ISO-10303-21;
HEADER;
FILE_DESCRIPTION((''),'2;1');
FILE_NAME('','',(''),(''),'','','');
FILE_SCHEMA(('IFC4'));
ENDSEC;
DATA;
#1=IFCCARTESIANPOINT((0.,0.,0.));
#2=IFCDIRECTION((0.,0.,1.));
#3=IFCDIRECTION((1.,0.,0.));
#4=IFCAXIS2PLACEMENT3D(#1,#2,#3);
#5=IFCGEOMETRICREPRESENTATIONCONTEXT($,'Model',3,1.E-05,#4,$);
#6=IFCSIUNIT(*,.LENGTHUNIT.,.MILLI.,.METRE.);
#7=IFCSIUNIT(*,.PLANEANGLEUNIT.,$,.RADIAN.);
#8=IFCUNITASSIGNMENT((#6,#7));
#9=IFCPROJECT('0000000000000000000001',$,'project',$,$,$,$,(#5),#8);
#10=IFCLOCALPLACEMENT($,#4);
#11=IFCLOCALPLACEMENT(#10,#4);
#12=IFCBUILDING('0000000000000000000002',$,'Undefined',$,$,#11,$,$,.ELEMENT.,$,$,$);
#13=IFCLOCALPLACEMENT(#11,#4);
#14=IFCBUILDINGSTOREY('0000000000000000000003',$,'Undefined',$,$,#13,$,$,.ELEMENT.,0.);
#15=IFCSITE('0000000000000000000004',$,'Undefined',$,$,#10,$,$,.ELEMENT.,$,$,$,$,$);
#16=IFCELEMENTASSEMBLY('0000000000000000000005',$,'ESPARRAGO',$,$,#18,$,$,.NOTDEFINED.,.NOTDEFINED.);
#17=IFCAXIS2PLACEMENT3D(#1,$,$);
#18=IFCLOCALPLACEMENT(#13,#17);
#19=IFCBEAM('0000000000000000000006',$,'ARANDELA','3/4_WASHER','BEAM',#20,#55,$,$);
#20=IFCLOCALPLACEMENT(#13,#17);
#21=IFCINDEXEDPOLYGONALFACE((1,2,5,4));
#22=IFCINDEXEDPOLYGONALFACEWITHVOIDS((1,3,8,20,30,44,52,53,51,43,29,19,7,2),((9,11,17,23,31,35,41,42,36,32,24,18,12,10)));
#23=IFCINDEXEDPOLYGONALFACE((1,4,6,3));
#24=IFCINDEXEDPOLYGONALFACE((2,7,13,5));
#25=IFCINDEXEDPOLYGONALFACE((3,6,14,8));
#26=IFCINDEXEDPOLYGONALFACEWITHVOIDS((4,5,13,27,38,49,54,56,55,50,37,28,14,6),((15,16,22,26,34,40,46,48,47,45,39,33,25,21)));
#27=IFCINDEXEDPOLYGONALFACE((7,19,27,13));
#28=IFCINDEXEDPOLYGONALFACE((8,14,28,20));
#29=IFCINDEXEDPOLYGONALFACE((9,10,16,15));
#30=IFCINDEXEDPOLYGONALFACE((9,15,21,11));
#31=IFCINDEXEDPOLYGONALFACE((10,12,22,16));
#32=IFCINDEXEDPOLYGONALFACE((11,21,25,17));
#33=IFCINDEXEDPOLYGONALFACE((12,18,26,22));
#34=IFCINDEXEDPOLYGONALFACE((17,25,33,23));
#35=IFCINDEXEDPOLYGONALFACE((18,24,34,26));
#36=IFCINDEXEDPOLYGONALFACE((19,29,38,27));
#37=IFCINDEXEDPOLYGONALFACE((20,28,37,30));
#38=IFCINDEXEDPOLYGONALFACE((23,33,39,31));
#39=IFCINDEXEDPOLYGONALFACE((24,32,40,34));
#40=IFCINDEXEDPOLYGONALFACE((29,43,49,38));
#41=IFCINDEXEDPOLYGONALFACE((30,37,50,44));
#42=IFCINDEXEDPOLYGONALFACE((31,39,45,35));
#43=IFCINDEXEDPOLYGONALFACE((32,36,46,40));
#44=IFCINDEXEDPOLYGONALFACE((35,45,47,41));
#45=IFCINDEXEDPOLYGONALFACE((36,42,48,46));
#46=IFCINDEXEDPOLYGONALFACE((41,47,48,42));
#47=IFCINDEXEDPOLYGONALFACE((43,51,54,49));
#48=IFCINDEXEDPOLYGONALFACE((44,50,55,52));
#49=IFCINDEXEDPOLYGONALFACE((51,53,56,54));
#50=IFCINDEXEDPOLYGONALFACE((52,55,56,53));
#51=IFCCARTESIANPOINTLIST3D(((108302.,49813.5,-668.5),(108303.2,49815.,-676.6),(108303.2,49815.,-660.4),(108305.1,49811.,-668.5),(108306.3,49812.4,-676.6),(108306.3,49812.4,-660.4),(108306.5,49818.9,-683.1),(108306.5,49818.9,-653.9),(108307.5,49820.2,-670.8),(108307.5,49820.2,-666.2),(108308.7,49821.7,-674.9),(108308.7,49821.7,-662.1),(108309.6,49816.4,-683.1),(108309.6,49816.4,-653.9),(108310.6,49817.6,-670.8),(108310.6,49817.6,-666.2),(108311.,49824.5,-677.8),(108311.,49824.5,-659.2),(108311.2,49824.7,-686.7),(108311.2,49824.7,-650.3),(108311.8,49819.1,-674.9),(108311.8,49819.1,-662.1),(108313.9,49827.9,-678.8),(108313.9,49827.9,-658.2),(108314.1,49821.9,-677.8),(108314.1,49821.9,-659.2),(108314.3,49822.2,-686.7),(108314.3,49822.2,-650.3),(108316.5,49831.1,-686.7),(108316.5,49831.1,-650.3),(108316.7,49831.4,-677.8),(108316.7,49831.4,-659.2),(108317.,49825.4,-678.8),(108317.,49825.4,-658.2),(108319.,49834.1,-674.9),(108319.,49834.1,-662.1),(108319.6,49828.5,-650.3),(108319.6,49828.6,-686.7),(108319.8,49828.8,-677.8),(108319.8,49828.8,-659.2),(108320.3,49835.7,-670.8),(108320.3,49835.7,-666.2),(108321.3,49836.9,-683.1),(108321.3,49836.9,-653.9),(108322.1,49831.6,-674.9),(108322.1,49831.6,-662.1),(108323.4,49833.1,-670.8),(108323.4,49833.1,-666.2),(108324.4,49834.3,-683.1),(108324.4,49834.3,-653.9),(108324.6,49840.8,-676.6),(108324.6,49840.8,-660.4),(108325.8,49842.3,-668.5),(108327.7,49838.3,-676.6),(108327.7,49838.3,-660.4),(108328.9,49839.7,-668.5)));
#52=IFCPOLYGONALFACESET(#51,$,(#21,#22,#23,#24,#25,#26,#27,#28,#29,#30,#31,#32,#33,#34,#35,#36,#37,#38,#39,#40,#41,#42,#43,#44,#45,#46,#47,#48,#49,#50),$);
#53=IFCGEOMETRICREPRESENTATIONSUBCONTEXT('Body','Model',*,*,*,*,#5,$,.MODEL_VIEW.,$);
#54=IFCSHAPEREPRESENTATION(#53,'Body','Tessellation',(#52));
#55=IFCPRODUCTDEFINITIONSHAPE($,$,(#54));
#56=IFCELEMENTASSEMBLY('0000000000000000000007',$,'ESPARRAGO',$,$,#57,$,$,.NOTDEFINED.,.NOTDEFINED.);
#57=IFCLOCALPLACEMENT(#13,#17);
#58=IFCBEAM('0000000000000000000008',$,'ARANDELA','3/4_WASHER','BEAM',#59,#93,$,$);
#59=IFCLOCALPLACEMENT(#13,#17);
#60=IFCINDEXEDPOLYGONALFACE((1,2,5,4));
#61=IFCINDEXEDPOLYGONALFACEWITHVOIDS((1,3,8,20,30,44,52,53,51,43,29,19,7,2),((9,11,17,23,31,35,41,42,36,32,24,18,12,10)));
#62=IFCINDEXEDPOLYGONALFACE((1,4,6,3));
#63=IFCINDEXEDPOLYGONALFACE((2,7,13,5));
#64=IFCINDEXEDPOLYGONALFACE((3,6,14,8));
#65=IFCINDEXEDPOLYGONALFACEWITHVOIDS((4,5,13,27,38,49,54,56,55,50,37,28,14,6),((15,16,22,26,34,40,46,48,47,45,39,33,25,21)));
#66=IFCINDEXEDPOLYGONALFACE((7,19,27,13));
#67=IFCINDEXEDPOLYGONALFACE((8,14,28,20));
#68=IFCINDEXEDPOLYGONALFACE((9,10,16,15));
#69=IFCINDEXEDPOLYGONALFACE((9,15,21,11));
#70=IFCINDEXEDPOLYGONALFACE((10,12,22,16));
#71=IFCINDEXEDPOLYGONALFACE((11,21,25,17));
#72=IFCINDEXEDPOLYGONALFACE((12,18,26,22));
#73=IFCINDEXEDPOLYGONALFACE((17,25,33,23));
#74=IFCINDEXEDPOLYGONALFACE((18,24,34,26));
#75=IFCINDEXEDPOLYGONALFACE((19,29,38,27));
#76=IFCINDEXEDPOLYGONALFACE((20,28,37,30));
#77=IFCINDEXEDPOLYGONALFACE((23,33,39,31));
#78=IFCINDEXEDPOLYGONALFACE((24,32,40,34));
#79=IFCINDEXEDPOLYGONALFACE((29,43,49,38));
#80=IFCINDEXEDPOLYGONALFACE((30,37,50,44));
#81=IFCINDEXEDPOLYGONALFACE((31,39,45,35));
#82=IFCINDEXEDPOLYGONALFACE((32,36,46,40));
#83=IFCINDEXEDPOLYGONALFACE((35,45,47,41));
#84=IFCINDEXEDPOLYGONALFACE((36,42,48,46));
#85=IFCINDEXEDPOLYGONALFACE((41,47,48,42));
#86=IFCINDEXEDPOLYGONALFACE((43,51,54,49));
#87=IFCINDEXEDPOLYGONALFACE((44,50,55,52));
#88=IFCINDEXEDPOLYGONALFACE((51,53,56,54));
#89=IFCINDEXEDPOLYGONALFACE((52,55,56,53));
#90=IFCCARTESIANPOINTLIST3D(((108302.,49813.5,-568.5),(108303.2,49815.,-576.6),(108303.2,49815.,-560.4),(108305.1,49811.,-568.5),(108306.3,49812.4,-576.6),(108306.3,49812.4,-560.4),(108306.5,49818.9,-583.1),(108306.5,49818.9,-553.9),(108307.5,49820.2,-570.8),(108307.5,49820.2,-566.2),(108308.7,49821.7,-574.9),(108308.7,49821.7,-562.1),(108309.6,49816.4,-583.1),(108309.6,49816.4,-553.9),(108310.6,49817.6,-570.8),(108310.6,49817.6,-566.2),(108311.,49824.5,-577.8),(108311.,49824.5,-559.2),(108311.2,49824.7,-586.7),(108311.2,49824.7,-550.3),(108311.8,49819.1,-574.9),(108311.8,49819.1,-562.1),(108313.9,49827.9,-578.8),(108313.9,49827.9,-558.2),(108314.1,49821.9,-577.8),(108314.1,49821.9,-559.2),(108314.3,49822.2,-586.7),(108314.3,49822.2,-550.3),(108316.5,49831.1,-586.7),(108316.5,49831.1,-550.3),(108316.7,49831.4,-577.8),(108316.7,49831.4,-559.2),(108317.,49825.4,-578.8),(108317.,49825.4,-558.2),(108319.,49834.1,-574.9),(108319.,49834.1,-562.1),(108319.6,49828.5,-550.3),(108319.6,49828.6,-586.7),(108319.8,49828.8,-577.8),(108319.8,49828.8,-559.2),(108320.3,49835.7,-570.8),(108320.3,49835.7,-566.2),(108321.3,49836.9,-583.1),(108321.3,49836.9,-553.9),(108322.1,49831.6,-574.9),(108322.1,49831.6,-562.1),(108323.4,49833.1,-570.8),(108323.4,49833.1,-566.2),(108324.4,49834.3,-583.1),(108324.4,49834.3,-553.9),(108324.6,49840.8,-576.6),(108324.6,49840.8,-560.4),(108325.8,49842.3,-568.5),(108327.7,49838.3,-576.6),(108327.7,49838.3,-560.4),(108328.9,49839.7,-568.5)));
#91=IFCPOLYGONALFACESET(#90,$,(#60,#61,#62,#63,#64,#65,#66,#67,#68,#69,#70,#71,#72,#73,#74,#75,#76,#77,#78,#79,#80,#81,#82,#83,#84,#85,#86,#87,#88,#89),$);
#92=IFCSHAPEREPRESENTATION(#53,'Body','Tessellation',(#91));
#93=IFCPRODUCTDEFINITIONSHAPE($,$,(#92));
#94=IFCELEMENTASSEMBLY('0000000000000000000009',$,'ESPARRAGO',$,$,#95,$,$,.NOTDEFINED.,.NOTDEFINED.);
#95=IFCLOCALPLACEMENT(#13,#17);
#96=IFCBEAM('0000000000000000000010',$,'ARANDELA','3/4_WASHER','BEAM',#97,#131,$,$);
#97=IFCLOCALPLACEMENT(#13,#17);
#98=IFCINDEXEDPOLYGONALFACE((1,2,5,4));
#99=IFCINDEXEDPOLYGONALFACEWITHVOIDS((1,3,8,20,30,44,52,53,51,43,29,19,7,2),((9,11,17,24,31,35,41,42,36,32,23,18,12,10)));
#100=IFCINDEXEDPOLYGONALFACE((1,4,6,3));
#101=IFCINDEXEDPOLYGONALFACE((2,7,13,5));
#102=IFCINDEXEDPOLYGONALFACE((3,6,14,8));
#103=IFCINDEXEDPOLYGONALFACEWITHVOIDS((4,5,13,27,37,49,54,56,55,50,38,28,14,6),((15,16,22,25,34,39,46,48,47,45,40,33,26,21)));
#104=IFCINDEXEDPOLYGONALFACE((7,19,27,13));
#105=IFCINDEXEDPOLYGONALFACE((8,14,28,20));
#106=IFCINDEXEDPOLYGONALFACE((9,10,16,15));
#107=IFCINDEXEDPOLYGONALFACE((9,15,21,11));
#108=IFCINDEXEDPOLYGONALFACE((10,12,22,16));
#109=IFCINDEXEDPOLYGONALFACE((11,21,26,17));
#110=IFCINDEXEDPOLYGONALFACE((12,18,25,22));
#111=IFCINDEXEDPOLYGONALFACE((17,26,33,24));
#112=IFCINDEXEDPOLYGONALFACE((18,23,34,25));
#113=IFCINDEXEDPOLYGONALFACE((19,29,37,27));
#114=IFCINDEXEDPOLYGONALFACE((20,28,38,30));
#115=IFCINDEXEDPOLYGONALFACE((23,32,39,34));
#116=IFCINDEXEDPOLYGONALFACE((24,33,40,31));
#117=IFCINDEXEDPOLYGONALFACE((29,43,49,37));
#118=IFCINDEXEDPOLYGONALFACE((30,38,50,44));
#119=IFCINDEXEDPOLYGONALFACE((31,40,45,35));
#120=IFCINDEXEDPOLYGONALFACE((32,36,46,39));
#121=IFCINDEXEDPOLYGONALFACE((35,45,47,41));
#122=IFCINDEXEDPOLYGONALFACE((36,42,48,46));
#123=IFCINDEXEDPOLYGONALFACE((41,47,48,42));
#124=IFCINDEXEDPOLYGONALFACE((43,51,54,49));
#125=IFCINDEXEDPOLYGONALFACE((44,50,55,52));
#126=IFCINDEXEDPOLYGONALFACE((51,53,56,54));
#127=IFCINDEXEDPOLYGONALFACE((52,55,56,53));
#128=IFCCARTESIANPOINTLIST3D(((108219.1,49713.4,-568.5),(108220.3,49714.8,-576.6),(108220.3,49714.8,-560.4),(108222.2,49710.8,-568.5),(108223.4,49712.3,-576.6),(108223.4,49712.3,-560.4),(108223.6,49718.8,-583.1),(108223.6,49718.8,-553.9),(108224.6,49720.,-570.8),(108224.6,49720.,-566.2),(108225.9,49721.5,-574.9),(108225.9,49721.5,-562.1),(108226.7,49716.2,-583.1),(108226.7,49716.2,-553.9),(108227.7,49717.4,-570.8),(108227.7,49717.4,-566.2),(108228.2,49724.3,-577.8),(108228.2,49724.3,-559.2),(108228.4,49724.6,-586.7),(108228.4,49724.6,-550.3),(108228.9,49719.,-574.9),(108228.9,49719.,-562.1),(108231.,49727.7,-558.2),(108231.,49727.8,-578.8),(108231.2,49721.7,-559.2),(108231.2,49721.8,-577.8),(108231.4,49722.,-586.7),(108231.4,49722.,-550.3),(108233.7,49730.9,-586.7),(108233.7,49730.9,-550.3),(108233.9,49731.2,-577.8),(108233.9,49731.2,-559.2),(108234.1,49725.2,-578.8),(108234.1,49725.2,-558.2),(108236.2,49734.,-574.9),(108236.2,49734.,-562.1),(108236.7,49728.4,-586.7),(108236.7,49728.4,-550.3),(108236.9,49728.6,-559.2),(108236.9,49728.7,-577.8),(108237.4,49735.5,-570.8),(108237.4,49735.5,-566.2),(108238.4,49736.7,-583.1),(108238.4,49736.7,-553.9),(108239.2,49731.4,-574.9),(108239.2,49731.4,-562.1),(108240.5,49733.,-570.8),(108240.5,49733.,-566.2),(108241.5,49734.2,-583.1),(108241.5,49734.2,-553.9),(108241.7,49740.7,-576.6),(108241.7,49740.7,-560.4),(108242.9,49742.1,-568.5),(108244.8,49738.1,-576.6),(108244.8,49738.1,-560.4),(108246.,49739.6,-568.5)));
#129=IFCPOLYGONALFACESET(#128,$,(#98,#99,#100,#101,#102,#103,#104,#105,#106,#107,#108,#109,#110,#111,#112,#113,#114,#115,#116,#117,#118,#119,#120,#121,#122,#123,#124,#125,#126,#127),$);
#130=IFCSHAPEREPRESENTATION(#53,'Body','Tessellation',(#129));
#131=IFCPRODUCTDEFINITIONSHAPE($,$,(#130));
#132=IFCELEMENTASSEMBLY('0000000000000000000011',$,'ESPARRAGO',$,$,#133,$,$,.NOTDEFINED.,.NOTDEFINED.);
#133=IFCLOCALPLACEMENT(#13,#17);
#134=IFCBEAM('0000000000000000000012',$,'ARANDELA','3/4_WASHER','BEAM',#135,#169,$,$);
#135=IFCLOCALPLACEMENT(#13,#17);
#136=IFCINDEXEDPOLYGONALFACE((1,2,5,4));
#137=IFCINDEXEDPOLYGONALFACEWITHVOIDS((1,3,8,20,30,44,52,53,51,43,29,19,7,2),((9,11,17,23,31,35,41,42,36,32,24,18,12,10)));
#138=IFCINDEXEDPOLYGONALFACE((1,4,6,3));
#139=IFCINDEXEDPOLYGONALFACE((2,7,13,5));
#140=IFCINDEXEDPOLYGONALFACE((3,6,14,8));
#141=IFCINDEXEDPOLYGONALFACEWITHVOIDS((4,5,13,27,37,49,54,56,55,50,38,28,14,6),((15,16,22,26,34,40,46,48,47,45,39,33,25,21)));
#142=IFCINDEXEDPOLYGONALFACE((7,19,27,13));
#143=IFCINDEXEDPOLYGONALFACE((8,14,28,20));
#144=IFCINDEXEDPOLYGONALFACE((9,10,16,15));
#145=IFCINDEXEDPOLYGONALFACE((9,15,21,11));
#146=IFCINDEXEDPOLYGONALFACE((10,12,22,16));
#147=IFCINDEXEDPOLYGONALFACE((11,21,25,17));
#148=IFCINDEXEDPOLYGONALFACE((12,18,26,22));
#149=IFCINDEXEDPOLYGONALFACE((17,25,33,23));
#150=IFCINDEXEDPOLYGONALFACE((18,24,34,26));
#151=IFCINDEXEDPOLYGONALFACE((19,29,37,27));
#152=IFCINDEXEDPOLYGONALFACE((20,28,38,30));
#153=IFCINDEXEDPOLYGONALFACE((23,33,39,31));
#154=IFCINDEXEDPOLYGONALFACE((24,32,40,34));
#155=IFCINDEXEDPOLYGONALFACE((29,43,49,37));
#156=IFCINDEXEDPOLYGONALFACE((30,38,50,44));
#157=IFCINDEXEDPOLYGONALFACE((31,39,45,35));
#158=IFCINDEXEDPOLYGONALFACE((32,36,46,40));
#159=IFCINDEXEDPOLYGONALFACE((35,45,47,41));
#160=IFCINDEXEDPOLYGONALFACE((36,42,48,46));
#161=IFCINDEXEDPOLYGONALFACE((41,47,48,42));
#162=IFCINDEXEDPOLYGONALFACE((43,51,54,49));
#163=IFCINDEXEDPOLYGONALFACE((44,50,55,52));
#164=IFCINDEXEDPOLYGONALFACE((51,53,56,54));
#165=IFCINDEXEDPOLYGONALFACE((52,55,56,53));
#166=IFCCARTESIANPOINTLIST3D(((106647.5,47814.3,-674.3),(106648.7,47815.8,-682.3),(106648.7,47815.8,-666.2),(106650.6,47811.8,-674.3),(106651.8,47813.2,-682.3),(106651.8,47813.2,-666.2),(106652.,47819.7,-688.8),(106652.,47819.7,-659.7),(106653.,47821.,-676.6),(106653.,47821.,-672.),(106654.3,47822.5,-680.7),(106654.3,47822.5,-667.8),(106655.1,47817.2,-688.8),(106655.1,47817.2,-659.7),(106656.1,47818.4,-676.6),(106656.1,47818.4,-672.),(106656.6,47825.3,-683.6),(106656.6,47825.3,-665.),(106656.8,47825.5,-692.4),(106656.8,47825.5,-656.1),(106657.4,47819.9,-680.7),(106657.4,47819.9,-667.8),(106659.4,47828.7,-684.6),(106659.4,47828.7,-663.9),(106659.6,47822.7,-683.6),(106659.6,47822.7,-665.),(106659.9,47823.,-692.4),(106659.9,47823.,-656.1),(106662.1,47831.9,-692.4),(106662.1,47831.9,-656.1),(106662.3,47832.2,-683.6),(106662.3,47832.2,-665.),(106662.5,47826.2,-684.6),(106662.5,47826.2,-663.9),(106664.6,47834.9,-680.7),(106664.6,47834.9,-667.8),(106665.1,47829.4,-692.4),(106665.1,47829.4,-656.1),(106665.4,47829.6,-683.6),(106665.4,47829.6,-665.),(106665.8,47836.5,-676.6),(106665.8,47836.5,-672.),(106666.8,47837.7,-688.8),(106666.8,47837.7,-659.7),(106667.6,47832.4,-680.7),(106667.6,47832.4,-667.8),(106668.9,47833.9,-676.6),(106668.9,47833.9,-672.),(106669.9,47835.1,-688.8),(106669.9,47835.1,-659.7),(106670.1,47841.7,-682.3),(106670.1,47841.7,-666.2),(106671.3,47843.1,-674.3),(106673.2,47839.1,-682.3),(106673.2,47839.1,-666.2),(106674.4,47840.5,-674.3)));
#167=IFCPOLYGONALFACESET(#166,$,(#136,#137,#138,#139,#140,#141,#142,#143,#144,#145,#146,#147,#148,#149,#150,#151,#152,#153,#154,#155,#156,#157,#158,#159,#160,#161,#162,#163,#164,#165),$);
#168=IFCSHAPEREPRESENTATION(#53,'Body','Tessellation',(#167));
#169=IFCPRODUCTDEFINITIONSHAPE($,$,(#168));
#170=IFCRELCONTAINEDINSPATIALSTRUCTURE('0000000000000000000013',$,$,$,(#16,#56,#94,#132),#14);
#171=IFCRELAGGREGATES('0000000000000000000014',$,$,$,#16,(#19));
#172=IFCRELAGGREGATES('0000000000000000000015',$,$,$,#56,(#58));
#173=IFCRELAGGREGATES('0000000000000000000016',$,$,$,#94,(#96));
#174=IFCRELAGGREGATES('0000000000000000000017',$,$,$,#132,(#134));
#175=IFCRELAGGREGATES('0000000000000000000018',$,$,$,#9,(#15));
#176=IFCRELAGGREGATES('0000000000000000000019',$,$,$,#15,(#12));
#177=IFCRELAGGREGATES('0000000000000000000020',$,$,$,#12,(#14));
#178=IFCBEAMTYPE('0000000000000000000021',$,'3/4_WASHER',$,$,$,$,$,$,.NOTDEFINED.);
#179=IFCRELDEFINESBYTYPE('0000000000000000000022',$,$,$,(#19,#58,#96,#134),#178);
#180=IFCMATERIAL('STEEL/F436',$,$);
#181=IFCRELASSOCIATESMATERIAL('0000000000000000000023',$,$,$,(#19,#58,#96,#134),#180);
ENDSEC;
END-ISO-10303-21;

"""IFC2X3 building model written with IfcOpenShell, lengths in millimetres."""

from ifc_helpers import new_model, si_unit, frame, origin_with_axes, place, context, subcontext, project, spatial, polyline, outline, extrude, material, type_object, element, aggregate, save


model = new_model("IFC2X3")

# Units and contexts
model_context = context("Model", 3, precision=1e-05, world=origin_with_axes())
body_context = subcontext(model_context, "Body", "Model", "MODEL_VIEW")
ifc_project = project(units=[si_unit("LENGTHUNIT", "METRE", prefix="MILLI"), si_unit("PLANEANGLEUNIT", "RADIAN")], contexts=[model_context])

# Site, building, storey
site_placement = place(None, origin_with_axes())
site = spatial("IfcSite", under=ifc_project, at=site_placement, Name="Undefined", CompositionType="ELEMENT")
building_placement = place(site_placement, origin_with_axes())
building = spatial("IfcBuilding", under=site, at=building_placement, Name="Undefined", CompositionType="ELEMENT")
storey_placement = place(building_placement, origin_with_axes())
storey = spatial("IfcBuildingStorey", under=building, at=storey_placement, Name="Undefined", CompositionType="ELEMENT", Elevation=0.0)

# Element assemblies, beams
ifc_material_1 = material(Name="STEEL/F436")
beam_type_1 = type_object("IfcBeamType", Name="3/4_WASHER", PredefinedType="NOTDEFINED")
assembly_1_placement = place(storey_placement, origin_with_axes())
assembly_1 = element("IfcElementAssembly", 1, at=assembly_1_placement, inside=storey, Name="ESPARRAGO", AssemblyPlace="NOTDEFINED", PredefinedType="NOTDEFINED")
beam_1_placement = place(assembly_1_placement, frame((108313.9, 49827.9, -668.5), z_axis=(0.000066, -0.000055, 1.0), x_axis=(0.7704, -0.637561, -0.000086)))
beam_1 = element("IfcBeam", 2, at=beam_1_placement, type_object=beam_type_1, material=ifc_material_1, Name="ARANDELA", Description="3/4_WASHER", ObjectType="BEAM", context=body_context, shape_type="SweptSolid", body=[
    extrude(outline(polyline([(-11.6, -14.6), (-16.8, -8.1), (-18.6, 0.0), (-16.8, 8.1), (-11.6, 14.6), (-4.2, 18.2), (4.2, 18.2), (11.6, 14.6), (16.8, 8.1), (18.6, 0.0), (16.8, -8.1), (11.6, -14.6), (4.2, -18.2), (-4.2, -18.2), (-11.6, -14.6)]), holes=[polyline([(-4.5, 9.3), (-8.1, 6.4), (-10.1, 2.3), (-10.1, -2.3), (-8.1, -6.4), (-4.5, -9.3), (0.0, -10.3), (4.5, -9.3), (8.1, -6.4), (10.1, -2.3), (10.1, 2.3), (8.1, 6.4), (4.5, 9.3), (0.0, 10.3), (-4.5, 9.3)])]), frame((4.0, 0.0, 0.0), z_axis=(-1.0, 0.0, 0.0), x_axis=(0.0, -1.0, 0.0)), (0.0, 0.0, 1.0), 4.0),
])
assembly_2_placement = place(storey_placement, origin_with_axes())
assembly_2 = element("IfcElementAssembly", 3, at=assembly_2_placement, inside=storey, Name="ESPARRAGO", AssemblyPlace="NOTDEFINED", PredefinedType="NOTDEFINED")
beam_2_placement = place(assembly_2_placement, frame((108313.9, 49827.9, -568.5), z_axis=(0.000066, -0.000055, 1.0), x_axis=(0.7704, -0.637561, -0.000086)))
beam_2 = element("IfcBeam", 4, at=beam_2_placement, type_object=beam_type_1, material=ifc_material_1, Name="ARANDELA", Description="3/4_WASHER", ObjectType="BEAM", context=body_context, shape_type="SweptSolid", body=[
    extrude(outline(polyline([(-11.6, -14.6), (-16.8, -8.1), (-18.6, 0.0), (-16.8, 8.1), (-11.6, 14.6), (-4.2, 18.2), (4.2, 18.2), (11.6, 14.6), (16.8, 8.1), (18.6, 0.0), (16.8, -8.1), (11.6, -14.6), (4.2, -18.2), (-4.2, -18.2), (-11.6, -14.6)]), holes=[polyline([(-4.5, 9.3), (-8.1, 6.4), (-10.1, 2.3), (-10.1, -2.3), (-8.1, -6.4), (-4.5, -9.3), (0.0, -10.3), (4.5, -9.3), (8.1, -6.4), (10.1, -2.3), (10.1, 2.3), (8.1, 6.4), (4.5, 9.3), (0.0, 10.3), (-4.5, 9.3)])]), frame((4.0, 0.0, 0.0), z_axis=(-1.0, 0.0, 0.0), x_axis=(0.0, -1.0, 0.0)), (0.0, 0.0, 1.0), 4.0),
])
assembly_3_placement = place(storey_placement, origin_with_axes())
assembly_3 = element("IfcElementAssembly", 5, at=assembly_3_placement, inside=storey, Name="ESPARRAGO", AssemblyPlace="NOTDEFINED", PredefinedType="NOTDEFINED")
beam_3_placement = place(assembly_3_placement, frame((108231.0, 49727.8, -568.5), z_axis=(0.000066, -0.000055, 1.0), x_axis=(0.7704, -0.637561, -0.000086)))
beam_3 = element("IfcBeam", 6, at=beam_3_placement, type_object=beam_type_1, material=ifc_material_1, Name="ARANDELA", Description="3/4_WASHER", ObjectType="BEAM", context=body_context, shape_type="SweptSolid", body=[
    extrude(outline(polyline([(-11.6, -14.6), (-16.8, -8.1), (-18.6, 0.0), (-16.8, 8.1), (-11.6, 14.6), (-4.2, 18.2), (4.2, 18.2), (11.6, 14.6), (16.8, 8.1), (18.6, 0.0), (16.8, -8.1), (11.6, -14.6), (4.2, -18.2), (-4.2, -18.2), (-11.6, -14.6)]), holes=[polyline([(-4.5, 9.3), (-8.1, 6.4), (-10.1, 2.3), (-10.1, -2.3), (-8.1, -6.4), (-4.5, -9.3), (0.0, -10.3), (4.5, -9.3), (8.1, -6.4), (10.1, -2.3), (10.1, 2.3), (8.1, 6.4), (4.5, 9.3), (0.0, 10.3), (-4.5, 9.3)])]), frame((4.0, 0.0, 0.0), z_axis=(-1.0, 0.0, 0.0), x_axis=(0.0, -1.0, 0.0)), (0.0, 0.0, 1.0), 4.0),
])
assembly_4_placement = place(storey_placement, origin_with_axes())
assembly_4 = element("IfcElementAssembly", 7, at=assembly_4_placement, inside=storey, Name="ESPARRAGO", AssemblyPlace="NOTDEFINED", PredefinedType="NOTDEFINED")
beam_4_placement = place(assembly_4_placement, frame((106659.4, 47828.7, -674.3), z_axis=(0.000066, -0.000055, 1.0), x_axis=(0.7704, -0.637561, -0.000086)))
beam_4 = element("IfcBeam", 8, at=beam_4_placement, type_object=beam_type_1, material=ifc_material_1, Name="ARANDELA", Description="3/4_WASHER", ObjectType="BEAM", context=body_context, shape_type="SweptSolid", body=[
    extrude(outline(polyline([(-11.6, -14.6), (-16.8, -8.1), (-18.6, 0.0), (-16.8, 8.1), (-11.6, 14.6), (-4.2, 18.2), (4.2, 18.2), (11.6, 14.6), (16.8, 8.1), (18.6, 0.0), (16.8, -8.1), (11.6, -14.6), (4.2, -18.2), (-4.2, -18.2), (-11.6, -14.6)]), holes=[polyline([(-4.5, 9.3), (-8.1, 6.4), (-10.1, 2.3), (-10.1, -2.3), (-8.1, -6.4), (-4.5, -9.3), (0.0, -10.3), (4.5, -9.3), (8.1, -6.4), (10.1, -2.3), (10.1, 2.3), (8.1, 6.4), (4.5, 9.3), (0.0, 10.3), (-4.5, 9.3)])]), frame((4.0, 0.0, 0.0), z_axis=(-1.0, 0.0, 0.0), x_axis=(0.0, -1.0, 0.0)), (0.0, 0.0, 1.0), 4.0),
])

aggregate(assembly_1, [beam_1])
aggregate(assembly_2, [beam_2])
aggregate(assembly_3, [beam_3])
aggregate(assembly_4, [beam_4])

save(model, "model.ifc")
